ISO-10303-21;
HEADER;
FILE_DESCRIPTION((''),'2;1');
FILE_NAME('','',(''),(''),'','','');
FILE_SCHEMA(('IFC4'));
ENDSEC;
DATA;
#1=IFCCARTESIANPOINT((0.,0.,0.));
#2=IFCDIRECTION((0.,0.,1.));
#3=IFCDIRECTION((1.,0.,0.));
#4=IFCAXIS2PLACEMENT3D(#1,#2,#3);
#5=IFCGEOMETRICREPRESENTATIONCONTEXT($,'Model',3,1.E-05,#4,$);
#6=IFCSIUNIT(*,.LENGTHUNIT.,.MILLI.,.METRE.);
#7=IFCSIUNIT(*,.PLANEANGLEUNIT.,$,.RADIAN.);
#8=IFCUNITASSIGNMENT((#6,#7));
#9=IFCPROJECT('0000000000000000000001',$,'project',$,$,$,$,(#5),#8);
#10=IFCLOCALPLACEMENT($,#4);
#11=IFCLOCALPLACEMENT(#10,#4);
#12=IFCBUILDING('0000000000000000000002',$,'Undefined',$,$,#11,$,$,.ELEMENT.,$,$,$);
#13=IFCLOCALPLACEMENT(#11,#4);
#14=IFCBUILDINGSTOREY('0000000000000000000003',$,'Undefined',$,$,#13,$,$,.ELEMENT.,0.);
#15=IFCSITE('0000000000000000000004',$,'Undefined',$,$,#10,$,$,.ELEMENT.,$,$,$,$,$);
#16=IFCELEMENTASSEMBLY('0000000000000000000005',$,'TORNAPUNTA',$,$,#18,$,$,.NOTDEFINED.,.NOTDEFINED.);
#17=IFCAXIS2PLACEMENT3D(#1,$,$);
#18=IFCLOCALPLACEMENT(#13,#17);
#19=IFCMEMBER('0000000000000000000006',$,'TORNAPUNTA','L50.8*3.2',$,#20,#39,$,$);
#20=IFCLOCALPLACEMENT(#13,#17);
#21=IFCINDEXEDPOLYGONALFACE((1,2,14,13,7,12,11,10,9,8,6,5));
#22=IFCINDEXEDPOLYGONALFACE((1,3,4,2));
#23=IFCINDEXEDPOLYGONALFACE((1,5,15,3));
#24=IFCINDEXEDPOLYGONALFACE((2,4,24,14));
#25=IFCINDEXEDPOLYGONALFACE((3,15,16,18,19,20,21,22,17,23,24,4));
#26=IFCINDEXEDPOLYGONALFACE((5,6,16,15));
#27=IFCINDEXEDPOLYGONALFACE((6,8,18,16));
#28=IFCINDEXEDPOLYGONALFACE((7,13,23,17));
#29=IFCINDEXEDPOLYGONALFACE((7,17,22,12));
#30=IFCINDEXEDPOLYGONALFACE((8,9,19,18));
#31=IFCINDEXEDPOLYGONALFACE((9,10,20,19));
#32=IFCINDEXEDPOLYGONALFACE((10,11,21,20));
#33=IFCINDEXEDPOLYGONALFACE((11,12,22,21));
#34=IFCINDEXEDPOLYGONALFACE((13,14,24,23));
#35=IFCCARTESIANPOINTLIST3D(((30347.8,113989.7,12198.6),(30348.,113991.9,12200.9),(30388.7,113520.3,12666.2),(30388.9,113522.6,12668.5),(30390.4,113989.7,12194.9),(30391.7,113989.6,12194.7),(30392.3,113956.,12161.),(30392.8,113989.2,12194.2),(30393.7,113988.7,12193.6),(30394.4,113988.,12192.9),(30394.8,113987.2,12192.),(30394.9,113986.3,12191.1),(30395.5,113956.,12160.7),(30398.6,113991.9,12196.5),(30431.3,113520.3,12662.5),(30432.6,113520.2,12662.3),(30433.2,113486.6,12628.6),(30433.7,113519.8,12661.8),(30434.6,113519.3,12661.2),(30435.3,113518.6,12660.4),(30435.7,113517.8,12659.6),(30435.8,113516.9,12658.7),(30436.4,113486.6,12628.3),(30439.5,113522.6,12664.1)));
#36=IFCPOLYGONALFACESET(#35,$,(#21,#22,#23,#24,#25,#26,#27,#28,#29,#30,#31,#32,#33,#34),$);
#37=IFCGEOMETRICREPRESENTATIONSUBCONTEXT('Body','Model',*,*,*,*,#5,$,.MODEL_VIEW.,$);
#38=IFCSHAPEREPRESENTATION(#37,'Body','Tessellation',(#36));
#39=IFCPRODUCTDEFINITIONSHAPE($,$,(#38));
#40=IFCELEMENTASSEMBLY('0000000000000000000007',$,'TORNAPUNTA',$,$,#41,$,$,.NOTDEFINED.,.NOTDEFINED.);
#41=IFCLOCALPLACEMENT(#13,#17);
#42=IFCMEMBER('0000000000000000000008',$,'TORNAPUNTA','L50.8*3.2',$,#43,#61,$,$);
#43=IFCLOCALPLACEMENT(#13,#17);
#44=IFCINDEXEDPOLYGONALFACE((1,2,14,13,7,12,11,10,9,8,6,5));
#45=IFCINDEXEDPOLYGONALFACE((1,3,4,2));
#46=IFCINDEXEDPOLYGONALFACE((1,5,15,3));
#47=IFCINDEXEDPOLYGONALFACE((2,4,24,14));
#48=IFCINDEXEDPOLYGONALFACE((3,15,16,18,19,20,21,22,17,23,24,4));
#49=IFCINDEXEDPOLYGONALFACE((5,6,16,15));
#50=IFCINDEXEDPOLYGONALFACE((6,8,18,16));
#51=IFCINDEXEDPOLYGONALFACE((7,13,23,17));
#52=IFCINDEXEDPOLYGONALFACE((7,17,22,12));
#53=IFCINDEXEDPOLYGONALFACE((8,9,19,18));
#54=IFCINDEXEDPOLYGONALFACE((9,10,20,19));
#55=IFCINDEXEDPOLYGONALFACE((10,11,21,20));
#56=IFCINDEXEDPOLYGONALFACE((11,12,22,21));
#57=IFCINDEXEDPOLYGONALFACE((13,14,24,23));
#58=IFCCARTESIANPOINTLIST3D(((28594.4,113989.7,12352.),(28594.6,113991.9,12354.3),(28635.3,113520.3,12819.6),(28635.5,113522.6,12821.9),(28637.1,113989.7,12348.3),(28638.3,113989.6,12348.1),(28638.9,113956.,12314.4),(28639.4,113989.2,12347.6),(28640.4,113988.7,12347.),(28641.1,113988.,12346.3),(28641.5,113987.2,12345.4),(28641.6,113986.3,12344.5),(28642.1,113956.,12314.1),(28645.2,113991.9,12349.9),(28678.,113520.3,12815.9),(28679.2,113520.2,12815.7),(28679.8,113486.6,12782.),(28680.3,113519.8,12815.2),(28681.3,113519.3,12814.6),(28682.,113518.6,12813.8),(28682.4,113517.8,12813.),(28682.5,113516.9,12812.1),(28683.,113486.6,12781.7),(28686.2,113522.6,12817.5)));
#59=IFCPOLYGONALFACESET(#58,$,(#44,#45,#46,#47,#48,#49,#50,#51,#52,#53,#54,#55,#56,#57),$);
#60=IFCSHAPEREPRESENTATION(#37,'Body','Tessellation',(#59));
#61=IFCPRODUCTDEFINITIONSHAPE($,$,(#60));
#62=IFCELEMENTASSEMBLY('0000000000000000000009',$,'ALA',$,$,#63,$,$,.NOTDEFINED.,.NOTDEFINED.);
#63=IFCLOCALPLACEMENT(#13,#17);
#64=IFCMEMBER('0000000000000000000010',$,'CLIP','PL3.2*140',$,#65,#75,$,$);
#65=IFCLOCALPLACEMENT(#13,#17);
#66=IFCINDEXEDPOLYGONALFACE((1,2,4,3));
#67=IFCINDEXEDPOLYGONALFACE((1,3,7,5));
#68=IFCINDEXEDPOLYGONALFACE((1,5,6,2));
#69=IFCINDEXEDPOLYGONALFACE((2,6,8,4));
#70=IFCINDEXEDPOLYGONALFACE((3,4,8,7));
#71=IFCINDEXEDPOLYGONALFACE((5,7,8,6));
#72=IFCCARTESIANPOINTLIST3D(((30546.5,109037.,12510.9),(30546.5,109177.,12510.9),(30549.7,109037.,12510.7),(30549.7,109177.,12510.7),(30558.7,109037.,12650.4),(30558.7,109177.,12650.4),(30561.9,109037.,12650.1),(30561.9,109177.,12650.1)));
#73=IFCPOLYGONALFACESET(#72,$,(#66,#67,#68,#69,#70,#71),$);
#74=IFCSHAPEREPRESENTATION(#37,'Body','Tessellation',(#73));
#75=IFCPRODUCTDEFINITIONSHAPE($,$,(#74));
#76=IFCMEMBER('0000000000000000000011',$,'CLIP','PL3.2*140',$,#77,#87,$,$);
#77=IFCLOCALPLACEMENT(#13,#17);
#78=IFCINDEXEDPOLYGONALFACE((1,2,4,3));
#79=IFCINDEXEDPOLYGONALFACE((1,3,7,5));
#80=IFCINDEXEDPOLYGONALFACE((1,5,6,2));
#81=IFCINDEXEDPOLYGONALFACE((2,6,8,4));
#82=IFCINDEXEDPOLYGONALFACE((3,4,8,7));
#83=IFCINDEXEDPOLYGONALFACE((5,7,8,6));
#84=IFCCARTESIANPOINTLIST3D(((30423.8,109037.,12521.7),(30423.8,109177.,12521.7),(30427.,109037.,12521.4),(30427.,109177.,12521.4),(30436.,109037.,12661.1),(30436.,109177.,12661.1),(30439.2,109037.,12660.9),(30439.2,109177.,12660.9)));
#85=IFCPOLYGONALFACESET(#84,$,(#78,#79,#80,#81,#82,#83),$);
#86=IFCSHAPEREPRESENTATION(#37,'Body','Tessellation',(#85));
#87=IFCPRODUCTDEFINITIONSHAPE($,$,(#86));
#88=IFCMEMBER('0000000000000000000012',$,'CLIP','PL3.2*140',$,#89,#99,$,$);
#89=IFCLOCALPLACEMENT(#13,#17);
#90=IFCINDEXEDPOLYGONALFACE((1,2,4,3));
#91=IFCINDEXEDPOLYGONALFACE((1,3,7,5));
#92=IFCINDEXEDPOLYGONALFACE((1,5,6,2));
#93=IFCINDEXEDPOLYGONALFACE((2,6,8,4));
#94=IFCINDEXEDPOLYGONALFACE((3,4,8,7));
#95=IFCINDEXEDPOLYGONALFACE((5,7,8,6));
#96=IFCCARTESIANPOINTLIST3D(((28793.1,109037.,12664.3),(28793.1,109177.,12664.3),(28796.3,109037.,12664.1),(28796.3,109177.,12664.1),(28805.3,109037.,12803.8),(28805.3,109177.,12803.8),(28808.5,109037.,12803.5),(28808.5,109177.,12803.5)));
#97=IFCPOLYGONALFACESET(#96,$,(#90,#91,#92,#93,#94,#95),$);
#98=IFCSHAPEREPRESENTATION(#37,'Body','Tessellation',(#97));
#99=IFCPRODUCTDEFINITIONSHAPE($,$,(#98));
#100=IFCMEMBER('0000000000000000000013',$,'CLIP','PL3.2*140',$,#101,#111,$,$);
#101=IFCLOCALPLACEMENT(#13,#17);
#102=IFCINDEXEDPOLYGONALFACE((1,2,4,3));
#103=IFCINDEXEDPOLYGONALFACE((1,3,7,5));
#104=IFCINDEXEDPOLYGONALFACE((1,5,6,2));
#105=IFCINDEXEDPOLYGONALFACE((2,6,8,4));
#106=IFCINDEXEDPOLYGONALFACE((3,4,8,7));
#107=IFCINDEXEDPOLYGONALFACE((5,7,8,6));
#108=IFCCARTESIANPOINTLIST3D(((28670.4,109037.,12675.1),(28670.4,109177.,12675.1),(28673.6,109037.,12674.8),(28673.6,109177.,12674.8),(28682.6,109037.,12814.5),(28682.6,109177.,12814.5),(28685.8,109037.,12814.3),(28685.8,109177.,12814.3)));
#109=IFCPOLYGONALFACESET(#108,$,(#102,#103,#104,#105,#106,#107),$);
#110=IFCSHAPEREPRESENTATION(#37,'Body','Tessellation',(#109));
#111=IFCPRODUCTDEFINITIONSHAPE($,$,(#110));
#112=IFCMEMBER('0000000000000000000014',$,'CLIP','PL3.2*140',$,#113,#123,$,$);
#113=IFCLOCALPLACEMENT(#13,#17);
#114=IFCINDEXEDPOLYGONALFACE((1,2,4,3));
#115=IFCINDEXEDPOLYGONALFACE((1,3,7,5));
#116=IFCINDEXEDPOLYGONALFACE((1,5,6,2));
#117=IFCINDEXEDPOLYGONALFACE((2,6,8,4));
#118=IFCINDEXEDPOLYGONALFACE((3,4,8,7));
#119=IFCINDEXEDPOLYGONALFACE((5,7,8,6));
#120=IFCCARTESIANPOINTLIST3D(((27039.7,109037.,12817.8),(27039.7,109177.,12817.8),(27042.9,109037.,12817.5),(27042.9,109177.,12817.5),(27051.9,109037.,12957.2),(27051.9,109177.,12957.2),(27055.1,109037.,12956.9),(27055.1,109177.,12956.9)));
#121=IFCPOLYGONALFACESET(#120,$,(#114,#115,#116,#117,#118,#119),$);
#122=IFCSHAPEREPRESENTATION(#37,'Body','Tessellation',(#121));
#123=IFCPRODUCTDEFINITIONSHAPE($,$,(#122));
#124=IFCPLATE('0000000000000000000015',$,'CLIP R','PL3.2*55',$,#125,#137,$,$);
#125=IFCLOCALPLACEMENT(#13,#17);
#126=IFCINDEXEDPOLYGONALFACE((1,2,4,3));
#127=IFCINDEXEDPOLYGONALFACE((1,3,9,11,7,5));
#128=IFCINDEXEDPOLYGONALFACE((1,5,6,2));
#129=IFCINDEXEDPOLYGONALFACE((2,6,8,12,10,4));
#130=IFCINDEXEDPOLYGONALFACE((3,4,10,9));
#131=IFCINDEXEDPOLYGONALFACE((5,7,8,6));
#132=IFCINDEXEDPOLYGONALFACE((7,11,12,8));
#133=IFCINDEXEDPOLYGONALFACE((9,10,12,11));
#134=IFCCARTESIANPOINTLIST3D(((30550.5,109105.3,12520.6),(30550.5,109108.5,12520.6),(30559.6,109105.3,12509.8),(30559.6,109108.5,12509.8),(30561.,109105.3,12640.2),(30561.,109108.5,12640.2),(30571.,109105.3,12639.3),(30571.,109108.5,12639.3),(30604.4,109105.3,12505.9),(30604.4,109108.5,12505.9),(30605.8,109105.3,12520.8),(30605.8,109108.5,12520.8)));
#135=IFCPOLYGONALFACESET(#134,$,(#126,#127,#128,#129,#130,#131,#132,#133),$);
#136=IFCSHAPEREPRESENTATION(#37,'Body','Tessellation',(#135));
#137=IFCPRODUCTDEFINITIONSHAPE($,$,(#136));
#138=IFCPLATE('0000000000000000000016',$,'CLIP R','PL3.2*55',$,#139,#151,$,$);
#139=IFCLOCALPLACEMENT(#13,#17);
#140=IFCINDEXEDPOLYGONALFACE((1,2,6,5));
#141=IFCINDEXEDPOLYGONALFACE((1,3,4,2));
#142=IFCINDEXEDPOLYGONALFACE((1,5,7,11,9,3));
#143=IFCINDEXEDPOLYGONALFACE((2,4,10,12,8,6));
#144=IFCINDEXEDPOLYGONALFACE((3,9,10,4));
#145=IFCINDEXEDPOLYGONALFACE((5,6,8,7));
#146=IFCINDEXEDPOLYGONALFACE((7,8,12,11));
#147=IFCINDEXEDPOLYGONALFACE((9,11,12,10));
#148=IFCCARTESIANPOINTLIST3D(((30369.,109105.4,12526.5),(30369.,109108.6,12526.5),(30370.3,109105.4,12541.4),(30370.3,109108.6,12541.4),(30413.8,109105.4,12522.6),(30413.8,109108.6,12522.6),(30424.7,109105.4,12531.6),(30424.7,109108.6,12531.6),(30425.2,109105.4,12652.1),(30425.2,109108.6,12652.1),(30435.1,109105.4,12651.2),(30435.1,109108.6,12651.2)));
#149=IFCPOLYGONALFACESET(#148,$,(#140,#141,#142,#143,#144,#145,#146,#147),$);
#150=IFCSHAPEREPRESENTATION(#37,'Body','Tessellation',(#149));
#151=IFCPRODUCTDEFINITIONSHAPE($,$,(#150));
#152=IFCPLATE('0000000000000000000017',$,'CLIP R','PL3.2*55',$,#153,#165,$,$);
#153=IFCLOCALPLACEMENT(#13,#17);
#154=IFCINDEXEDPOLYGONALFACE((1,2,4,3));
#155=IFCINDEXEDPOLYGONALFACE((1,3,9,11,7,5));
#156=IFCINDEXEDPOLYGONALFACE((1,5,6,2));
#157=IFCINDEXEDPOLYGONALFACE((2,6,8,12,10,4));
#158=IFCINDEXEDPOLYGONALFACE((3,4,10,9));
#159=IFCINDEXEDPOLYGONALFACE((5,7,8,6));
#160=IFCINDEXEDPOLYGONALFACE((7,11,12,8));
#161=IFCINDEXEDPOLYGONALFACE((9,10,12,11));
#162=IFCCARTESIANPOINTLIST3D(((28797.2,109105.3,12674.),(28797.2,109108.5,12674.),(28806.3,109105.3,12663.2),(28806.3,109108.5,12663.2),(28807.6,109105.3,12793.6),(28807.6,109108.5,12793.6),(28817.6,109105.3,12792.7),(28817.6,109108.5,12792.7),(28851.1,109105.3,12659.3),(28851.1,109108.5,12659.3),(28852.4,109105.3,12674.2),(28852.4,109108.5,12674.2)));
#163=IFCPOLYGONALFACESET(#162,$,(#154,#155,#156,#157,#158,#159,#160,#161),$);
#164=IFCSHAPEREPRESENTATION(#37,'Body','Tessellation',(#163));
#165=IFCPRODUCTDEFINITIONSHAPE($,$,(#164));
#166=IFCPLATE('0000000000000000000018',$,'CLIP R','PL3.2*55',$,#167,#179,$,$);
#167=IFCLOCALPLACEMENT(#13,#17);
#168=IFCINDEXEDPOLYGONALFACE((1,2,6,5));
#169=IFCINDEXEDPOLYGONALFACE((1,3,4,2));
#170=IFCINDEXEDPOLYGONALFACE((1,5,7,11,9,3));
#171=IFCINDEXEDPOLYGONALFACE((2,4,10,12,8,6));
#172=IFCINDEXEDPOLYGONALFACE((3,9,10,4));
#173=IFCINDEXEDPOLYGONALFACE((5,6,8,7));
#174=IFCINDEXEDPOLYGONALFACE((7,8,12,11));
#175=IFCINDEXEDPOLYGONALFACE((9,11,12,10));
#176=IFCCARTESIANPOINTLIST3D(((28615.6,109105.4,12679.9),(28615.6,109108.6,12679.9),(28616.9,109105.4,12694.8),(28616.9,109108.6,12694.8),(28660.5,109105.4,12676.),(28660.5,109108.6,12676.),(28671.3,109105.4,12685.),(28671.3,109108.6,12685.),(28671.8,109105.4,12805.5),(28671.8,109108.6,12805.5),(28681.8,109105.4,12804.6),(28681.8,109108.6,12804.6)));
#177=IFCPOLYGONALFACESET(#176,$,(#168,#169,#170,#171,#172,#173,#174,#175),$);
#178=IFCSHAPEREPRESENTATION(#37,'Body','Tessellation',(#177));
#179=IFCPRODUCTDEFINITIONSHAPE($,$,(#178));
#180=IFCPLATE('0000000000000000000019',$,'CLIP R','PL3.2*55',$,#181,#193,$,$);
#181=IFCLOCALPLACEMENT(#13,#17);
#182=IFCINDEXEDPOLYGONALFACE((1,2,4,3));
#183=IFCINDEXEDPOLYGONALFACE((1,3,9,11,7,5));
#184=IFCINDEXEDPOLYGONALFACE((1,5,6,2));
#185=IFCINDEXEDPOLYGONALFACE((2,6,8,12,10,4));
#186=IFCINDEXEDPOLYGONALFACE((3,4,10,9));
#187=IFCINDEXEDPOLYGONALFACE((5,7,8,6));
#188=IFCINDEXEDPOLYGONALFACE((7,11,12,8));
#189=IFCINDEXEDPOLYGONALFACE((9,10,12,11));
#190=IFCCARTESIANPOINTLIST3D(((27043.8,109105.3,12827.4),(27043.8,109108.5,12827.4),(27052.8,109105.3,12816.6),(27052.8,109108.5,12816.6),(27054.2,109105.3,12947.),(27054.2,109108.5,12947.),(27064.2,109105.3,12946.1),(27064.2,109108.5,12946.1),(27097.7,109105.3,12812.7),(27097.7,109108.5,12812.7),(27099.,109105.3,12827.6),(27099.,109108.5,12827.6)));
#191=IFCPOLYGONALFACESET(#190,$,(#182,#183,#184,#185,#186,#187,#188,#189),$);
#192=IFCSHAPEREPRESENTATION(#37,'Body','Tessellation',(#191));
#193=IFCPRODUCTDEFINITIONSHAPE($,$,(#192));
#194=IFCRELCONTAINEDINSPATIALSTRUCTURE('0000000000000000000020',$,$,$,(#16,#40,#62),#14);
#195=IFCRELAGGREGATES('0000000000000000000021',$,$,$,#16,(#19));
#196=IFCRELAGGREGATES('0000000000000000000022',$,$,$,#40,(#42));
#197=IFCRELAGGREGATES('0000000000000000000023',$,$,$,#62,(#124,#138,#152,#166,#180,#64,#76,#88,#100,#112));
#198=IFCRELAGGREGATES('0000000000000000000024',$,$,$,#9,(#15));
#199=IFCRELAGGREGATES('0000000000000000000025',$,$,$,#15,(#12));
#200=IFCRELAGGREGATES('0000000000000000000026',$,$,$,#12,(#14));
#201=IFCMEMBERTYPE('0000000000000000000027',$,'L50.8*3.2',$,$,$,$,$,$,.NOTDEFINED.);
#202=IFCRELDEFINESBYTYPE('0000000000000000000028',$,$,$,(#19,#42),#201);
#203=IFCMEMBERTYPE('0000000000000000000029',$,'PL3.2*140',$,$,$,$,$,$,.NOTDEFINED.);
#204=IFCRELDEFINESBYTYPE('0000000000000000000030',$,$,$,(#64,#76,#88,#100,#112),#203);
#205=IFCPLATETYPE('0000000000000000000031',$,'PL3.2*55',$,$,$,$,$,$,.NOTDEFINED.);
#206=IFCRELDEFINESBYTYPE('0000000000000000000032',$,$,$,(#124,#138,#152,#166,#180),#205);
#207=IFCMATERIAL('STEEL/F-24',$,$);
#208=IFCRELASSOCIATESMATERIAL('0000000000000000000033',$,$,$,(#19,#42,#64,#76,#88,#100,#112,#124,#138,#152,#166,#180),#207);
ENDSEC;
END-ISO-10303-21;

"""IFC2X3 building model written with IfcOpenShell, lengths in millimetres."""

from ifc_helpers import new_model, si_unit, frame, origin_with_axes, origin_2d_with_axis, place, context, subcontext, project, spatial, polyline, rectangle, l_section, outline, extrude, material, type_object, element, aggregate, save


model = new_model("IFC2X3")

# Units and contexts
model_context = context("Model", 3, precision=1e-05, world=origin_with_axes())
body_context = subcontext(model_context, "Body", "Model", "MODEL_VIEW")
ifc_project = project(units=[si_unit("LENGTHUNIT", "METRE", prefix="MILLI"), si_unit("PLANEANGLEUNIT", "RADIAN")], contexts=[model_context])

# Site, building, storey
site_placement = place(None, origin_with_axes())
site = spatial("IfcSite", under=ifc_project, at=site_placement, Name="Undefined", CompositionType="ELEMENT")
building_placement = place(site_placement, origin_with_axes())
building = spatial("IfcBuilding", under=site, at=building_placement, Name="Undefined", CompositionType="ELEMENT")
storey_placement = place(building_placement, origin_with_axes())
storey = spatial("IfcBuildingStorey", under=building, at=storey_placement, Name="Undefined", CompositionType="ELEMENT", Elevation=0.0)

# Element assemblies, members
assembly_1_placement = place(storey_placement, origin_with_axes())
assembly_1 = element("IfcElementAssembly", 1, at=assembly_1_placement, inside=storey, Name="TORNAPUNTA", AssemblyPlace="NOTDEFINED", PredefinedType="NOTDEFINED")
ifc_material_1 = material(Name="STEEL/F-24")
member_type_1 = type_object("IfcMemberType", Name="L50.8*3.2", PredefinedType="NOTDEFINED")
member_1_placement = place(assembly_1_placement, frame((30412.6, 113504.6, 12648.4), z_axis=(-0.061634, -0.707107, -0.704416), x_axis=(-0.061634, 0.707107, -0.704416)))
member_1 = element("IfcMember", 2, at=member_1_placement, type_object=member_type_1, material=ifc_material_1, Name="TORNAPUNTA", Description="L50.8*3.2", context=body_context, shape_type="SweptSolid", body=[
    extrude(l_section(Depth=50.8, Width=50.8, Thickness=3.2, FilletRadius=4.8, at=origin_2d_with_axis()), frame((663.8, 0.0, 0.0), z_axis=(-1.0, 0.0, 0.0), x_axis=(0.0, -1.0, 0.0)), (0.0, 0.0, 1.0), 663.8),
])
aggregate(assembly_1, [member_1])
assembly_2_placement = place(storey_placement, origin_with_axes())
assembly_2 = element("IfcElementAssembly", 3, at=assembly_2_placement, inside=storey, Name="TORNAPUNTA", AssemblyPlace="NOTDEFINED", PredefinedType="NOTDEFINED")
member_2_placement = place(assembly_2_placement, frame((28659.3, 113504.6, 12801.8), z_axis=(-0.061634, -0.707107, -0.704416), x_axis=(-0.061634, 0.707107, -0.704416)))
member_2 = element("IfcMember", 4, at=member_2_placement, type_object=member_type_1, material=ifc_material_1, Name="TORNAPUNTA", Description="L50.8*3.2", context=body_context, shape_type="SweptSolid", body=[
    extrude(l_section(Depth=50.8, Width=50.8, Thickness=3.2, FilletRadius=4.8, at=origin_2d_with_axis()), frame((663.8, 0.0, 0.0), z_axis=(-1.0, 0.0, 0.0), x_axis=(0.0, -1.0, 0.0)), (0.0, 0.0, 1.0), 663.8),
])
aggregate(assembly_2, [member_2])

# Element assembly, members, plates
assembly_3_placement = place(storey_placement, origin_with_axes())
assembly_3 = element("IfcElementAssembly", 5, at=assembly_3_placement, inside=storey, Name="ALA", AssemblyPlace="NOTDEFINED", PredefinedType="NOTDEFINED")
member_type_2 = type_object("IfcMemberType", Name="PL3.2*140", PredefinedType="NOTDEFINED")
member_3_placement = place(assembly_3_placement, frame((30560.3, 109107.0, 12650.3), z_axis=(0.0, -1.0, 0.0), x_axis=(-0.087155, 0.0, -0.996195)))
member_3 = element("IfcMember", 6, at=member_3_placement, type_object=member_type_2, material=ifc_material_1, Name="CLIP", Description="PL3.2*140", context=body_context, shape_type="SweptSolid", body=[
    extrude(rectangle(XDim=3.2, YDim=140.0, at=origin_2d_with_axis()), frame((140.0, 0.0, 0.0), z_axis=(-1.0, 0.0, 0.0), x_axis=(0.0, -1.0, 0.0)), (0.0, 0.0, 1.0), 140.0),
])
member_4_placement = place(assembly_3_placement, frame((30437.6, 109107.0, 12661.0), z_axis=(0.0, -1.0, 0.0), x_axis=(-0.087155, 0.0, -0.996195)))
member_4 = element("IfcMember", 7, at=member_4_placement, type_object=member_type_2, material=ifc_material_1, Name="CLIP", Description="PL3.2*140", context=body_context, shape_type="SweptSolid", body=[
    extrude(rectangle(XDim=3.2, YDim=140.0, at=origin_2d_with_axis()), frame((140.0, 0.0, 0.0), z_axis=(-1.0, 0.0, 0.0), x_axis=(0.0, -1.0, 0.0)), (0.0, 0.0, 1.0), 140.0),
])
member_5_placement = place(assembly_3_placement, frame((28806.9, 109107.0, 12803.7), z_axis=(0.0, -1.0, 0.0), x_axis=(-0.087155, 0.0, -0.996195)))
member_5 = element("IfcMember", 8, at=member_5_placement, type_object=member_type_2, material=ifc_material_1, Name="CLIP", Description="PL3.2*140", context=body_context, shape_type="SweptSolid", body=[
    extrude(rectangle(XDim=3.2, YDim=140.0, at=origin_2d_with_axis()), frame((140.0, 0.0, 0.0), z_axis=(-1.0, 0.0, 0.0), x_axis=(0.0, -1.0, 0.0)), (0.0, 0.0, 1.0), 140.0),
])
member_6_placement = place(assembly_3_placement, frame((28684.2, 109107.0, 12814.4), z_axis=(0.0, -1.0, 0.0), x_axis=(-0.087155, 0.0, -0.996195)))
member_6 = element("IfcMember", 9, at=member_6_placement, type_object=member_type_2, material=ifc_material_1, Name="CLIP", Description="PL3.2*140", context=body_context, shape_type="SweptSolid", body=[
    extrude(rectangle(XDim=3.2, YDim=140.0, at=origin_2d_with_axis()), frame((140.0, 0.0, 0.0), z_axis=(-1.0, 0.0, 0.0), x_axis=(0.0, -1.0, 0.0)), (0.0, 0.0, 1.0), 140.0),
])
member_7_placement = place(assembly_3_placement, frame((27053.5, 109107.0, 12957.1), z_axis=(0.0, -1.0, 0.0), x_axis=(-0.087155, 0.0, -0.996195)))
member_7 = element("IfcMember", 10, at=member_7_placement, type_object=member_type_2, material=ifc_material_1, Name="CLIP", Description="PL3.2*140", context=body_context, shape_type="SweptSolid", body=[
    extrude(rectangle(XDim=3.2, YDim=140.0, at=origin_2d_with_axis()), frame((140.0, 0.0, 0.0), z_axis=(-1.0, 0.0, 0.0), x_axis=(0.0, -1.0, 0.0)), (0.0, 0.0, 1.0), 140.0),
])
plate_type_1 = type_object("IfcPlateType", Name="PL3.2*55", PredefinedType="NOTDEFINED")
plate_1_placement = place(assembly_3_placement, frame((30561.0, 109106.9, 12640.2), z_axis=(0.0, 1.0, 0.0), x_axis=(0.996195, 0.0, -0.087155)))
plate_1 = element("IfcPlate", 11, at=plate_1_placement, type_object=plate_type_1, material=ifc_material_1, Name="CLIP R", Description="PL3.2*55", context=body_context, shape_type="SweptSolid", body=[
    extrude(outline(polyline([(0.0, 0.0), (10.0, 0.0), (55.0, 115.0), (55.0, 130.0), (10.0, 130.0), (0.0, 120.0), (0.0, 0.0)])), frame((0.0, 0.0, -1.6), z_axis=(0.0, 0.0, 1.0), x_axis=(1.0, 0.0, 0.0)), (0.0, 0.0, 1.0), 3.2),
])
plate_2_placement = place(assembly_3_placement, frame((30435.1, 109107.0, 12651.2), z_axis=(0.0, -1.0, 0.0), x_axis=(-0.996195, 0.0, 0.087155)))
plate_2 = element("IfcPlate", 12, at=plate_2_placement, type_object=plate_type_1, material=ifc_material_1, Name="CLIP R", Description="PL3.2*55", context=body_context, shape_type="SweptSolid", body=[
    extrude(outline(polyline([(0.0, 0.0), (10.0, 0.0), (55.0, 115.0), (55.0, 130.0), (10.0, 130.0), (0.0, 120.0), (0.0, 0.0)])), frame((0.0, 0.0, -1.6), z_axis=(0.0, 0.0, 1.0), x_axis=(1.0, 0.0, 0.0)), (0.0, 0.0, 1.0), 3.2),
])
plate_3_placement = place(assembly_3_placement, frame((28807.6, 109106.9, 12793.6), z_axis=(0.0, 1.0, 0.0), x_axis=(0.996195, 0.0, -0.087155)))
plate_3 = element("IfcPlate", 13, at=plate_3_placement, type_object=plate_type_1, material=ifc_material_1, Name="CLIP R", Description="PL3.2*55", context=body_context, shape_type="SweptSolid", body=[
    extrude(outline(polyline([(0.0, 0.0), (10.0, 0.0), (55.0, 115.0), (55.0, 130.0), (10.0, 130.0), (0.0, 120.0), (0.0, 0.0)])), frame((0.0, 0.0, -1.6), z_axis=(0.0, 0.0, 1.0), x_axis=(1.0, 0.0, 0.0)), (0.0, 0.0, 1.0), 3.2),
])
plate_4_placement = place(assembly_3_placement, frame((28681.8, 109107.0, 12804.6), z_axis=(0.0, -1.0, 0.0), x_axis=(-0.996195, 0.0, 0.087155)))
plate_4 = element("IfcPlate", 14, at=plate_4_placement, type_object=plate_type_1, material=ifc_material_1, Name="CLIP R", Description="PL3.2*55", context=body_context, shape_type="SweptSolid", body=[
    extrude(outline(polyline([(0.0, 0.0), (10.0, 0.0), (55.0, 115.0), (55.0, 130.0), (10.0, 130.0), (0.0, 120.0), (0.0, 0.0)])), frame((0.0, 0.0, -1.6), z_axis=(0.0, 0.0, 1.0), x_axis=(1.0, 0.0, 0.0)), (0.0, 0.0, 1.0), 3.2),
])
plate_5_placement = place(assembly_3_placement, frame((27054.2, 109106.9, 12947.0), z_axis=(0.0, 1.0, 0.0), x_axis=(0.996195, 0.0, -0.087155)))
plate_5 = element("IfcPlate", 15, at=plate_5_placement, type_object=plate_type_1, material=ifc_material_1, Name="CLIP R", Description="PL3.2*55", context=body_context, shape_type="SweptSolid", body=[
    extrude(outline(polyline([(0.0, 0.0), (10.0, 0.0), (55.0, 115.0), (55.0, 130.0), (10.0, 130.0), (0.0, 120.0), (0.0, 0.0)])), frame((0.0, 0.0, -1.6), z_axis=(0.0, 0.0, 1.0), x_axis=(1.0, 0.0, 0.0)), (0.0, 0.0, 1.0), 3.2),
])
aggregate(assembly_3, [plate_1, plate_2, plate_3, plate_4, plate_5, member_3, member_4, member_5, member_6, member_7])

save(model, "model.ifc")
